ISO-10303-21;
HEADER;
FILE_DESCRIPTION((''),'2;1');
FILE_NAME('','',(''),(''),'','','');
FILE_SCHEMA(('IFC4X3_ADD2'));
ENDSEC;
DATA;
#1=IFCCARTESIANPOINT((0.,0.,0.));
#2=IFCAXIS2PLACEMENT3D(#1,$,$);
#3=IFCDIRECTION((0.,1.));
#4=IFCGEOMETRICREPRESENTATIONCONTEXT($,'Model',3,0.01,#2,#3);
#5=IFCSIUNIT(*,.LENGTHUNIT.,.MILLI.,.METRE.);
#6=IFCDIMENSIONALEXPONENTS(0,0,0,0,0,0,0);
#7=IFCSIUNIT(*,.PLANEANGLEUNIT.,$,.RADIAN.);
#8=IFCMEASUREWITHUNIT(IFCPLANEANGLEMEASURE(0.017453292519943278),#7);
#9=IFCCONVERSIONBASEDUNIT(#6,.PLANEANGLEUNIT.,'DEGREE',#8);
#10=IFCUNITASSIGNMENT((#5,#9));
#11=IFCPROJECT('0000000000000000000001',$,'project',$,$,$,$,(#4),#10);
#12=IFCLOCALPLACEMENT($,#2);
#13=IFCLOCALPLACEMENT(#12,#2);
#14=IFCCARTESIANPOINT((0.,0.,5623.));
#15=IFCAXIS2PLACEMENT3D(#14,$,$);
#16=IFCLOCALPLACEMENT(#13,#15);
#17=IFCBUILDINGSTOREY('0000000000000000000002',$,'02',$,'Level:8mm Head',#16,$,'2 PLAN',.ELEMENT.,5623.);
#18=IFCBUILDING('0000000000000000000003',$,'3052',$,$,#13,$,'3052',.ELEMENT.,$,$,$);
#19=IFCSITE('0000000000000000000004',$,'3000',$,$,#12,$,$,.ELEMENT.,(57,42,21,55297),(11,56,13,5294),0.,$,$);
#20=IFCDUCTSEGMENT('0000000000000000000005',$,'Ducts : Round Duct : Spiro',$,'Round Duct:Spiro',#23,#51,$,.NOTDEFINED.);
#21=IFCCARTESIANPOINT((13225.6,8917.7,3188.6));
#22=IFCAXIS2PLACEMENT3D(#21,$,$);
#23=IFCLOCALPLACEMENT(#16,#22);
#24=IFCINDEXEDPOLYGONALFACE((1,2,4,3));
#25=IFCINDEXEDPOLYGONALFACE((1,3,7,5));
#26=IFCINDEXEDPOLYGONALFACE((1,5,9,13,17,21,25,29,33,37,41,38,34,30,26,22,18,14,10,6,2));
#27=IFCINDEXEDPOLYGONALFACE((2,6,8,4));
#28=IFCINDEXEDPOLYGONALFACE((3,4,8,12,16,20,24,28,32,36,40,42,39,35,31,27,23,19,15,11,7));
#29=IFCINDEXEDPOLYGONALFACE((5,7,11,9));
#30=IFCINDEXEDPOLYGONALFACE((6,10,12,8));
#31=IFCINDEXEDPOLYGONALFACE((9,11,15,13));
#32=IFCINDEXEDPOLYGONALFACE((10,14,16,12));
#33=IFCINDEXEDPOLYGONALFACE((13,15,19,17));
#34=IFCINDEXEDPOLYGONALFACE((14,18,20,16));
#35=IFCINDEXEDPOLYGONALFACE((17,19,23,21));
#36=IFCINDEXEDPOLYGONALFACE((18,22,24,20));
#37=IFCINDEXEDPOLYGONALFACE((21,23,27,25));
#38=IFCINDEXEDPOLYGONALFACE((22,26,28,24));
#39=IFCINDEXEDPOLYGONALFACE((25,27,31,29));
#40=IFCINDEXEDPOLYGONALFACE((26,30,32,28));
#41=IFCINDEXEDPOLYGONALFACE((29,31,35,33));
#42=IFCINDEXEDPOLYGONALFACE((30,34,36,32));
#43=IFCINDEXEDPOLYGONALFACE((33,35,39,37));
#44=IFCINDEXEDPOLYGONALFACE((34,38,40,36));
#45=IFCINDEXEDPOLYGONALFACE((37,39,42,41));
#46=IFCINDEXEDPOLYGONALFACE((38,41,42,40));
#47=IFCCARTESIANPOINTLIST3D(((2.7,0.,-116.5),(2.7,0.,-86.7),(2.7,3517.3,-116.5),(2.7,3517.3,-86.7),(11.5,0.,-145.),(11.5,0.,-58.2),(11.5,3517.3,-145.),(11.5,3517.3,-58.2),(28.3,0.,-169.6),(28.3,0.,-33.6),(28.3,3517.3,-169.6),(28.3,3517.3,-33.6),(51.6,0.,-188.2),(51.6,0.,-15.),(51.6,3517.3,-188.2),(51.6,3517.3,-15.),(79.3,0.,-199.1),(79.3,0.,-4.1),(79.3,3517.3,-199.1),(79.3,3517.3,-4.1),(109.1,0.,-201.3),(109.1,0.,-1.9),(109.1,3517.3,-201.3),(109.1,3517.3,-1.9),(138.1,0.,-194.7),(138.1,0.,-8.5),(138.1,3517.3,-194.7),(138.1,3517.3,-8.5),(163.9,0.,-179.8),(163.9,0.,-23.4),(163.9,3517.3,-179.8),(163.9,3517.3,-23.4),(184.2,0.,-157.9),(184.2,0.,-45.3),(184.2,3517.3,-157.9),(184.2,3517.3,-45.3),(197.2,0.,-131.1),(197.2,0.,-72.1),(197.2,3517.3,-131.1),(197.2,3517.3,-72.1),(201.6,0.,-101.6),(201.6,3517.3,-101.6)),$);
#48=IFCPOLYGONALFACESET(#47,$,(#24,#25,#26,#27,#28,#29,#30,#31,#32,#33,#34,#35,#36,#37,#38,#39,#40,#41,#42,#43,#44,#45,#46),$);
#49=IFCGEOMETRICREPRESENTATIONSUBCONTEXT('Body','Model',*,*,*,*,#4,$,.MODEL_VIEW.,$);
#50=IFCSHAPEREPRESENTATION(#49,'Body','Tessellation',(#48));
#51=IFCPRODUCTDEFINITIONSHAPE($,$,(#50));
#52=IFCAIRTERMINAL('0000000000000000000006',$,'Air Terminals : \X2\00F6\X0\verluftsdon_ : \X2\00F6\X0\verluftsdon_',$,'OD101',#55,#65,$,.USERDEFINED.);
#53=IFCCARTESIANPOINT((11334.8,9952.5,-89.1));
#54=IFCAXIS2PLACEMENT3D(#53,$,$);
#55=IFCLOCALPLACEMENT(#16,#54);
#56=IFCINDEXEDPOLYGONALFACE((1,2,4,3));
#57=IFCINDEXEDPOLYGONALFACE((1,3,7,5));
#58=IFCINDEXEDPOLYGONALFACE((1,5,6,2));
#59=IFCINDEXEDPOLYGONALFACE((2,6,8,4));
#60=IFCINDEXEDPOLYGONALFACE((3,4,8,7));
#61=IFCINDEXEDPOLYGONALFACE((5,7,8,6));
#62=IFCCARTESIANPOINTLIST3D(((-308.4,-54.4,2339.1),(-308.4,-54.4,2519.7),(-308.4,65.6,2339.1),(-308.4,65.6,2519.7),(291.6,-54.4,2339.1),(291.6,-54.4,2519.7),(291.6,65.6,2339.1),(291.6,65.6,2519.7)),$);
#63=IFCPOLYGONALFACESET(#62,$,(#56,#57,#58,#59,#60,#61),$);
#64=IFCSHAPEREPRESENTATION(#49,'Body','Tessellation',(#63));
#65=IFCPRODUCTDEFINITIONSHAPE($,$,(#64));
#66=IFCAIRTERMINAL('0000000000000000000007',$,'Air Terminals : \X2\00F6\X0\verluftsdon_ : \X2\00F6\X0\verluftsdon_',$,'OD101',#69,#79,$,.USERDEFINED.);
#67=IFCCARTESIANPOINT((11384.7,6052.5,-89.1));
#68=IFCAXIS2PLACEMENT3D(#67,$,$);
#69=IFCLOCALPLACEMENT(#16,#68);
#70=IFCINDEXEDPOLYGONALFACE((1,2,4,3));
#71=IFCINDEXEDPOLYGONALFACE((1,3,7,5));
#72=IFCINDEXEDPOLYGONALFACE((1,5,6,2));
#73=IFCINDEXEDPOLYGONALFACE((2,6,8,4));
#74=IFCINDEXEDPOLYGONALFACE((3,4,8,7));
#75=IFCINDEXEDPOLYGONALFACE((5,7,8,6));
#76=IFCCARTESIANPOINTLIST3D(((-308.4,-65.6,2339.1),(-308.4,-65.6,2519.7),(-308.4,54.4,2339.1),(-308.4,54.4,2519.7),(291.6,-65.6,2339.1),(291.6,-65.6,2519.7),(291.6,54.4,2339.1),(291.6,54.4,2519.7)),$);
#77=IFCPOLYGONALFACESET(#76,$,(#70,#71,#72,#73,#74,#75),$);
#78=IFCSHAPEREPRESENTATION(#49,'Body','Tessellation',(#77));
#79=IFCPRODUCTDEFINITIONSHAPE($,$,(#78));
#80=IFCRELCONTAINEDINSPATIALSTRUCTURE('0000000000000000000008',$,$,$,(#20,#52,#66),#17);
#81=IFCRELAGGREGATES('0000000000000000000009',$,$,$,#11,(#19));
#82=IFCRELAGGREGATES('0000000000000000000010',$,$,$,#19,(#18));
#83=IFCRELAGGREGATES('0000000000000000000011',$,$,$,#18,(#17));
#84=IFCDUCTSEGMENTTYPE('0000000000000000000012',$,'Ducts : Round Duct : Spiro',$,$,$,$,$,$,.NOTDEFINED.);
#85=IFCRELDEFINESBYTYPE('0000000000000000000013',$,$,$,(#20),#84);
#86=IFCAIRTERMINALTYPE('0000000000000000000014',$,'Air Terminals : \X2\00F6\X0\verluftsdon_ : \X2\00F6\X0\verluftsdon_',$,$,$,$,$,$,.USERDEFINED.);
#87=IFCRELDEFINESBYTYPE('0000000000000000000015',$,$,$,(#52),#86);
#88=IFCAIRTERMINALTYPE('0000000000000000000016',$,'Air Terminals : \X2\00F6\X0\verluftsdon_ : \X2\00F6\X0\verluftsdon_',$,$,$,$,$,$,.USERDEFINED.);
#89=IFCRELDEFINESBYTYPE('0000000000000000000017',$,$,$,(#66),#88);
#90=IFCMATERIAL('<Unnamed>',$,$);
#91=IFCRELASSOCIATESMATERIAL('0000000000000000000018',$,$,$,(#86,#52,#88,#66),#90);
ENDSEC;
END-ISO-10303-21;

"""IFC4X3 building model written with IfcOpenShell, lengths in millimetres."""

from ifc_helpers import new_model, entity, si_unit, converted_unit, direction, frame, origin, origin_2d_with_axis, place, context, subcontext, project, spatial, rectangle, circle, extrude, source, transform, mapped, material, type_object, type_shapes, element, save


model = new_model("IFC4X3")

# Units and contexts
model_context = context("Model", 3, precision=0.01, world=origin(), true_north=direction((0.0, 1.0)))
body_context = subcontext(model_context, "Body", "Model", "MODEL_VIEW")
ifc_project = project(units=[si_unit("LENGTHUNIT", "METRE", prefix="MILLI"), converted_unit("PLANEANGLEUNIT", "DEGREE", entity("IfcPlaneAngleMeasure", 0.017453292519943278), si_unit("PLANEANGLEUNIT", "RADIAN"), dimensions=[0, 0, 0, 0, 0, 0, 0])], contexts=[model_context])

# Site, building, storey
site_placement = place(None, origin())
site = spatial("IfcSite", under=ifc_project, at=site_placement, Name="3000", CompositionType="ELEMENT", RefLatitude=(57, 42, 21, 55297), RefLongitude=(11, 56, 13, 5294), RefElevation=0.0)
building_placement = place(site_placement, origin())
building = spatial("IfcBuilding", under=site, at=building_placement, Name="3052", LongName="3052", CompositionType="ELEMENT")
storey_placement = place(building_placement, frame((0.0, 0.0, 5623.0)))
storey = spatial("IfcBuildingStorey", under=building, at=storey_placement, Name="02", ObjectType="Level:8mm Head", LongName="2 PLAN", CompositionType="ELEMENT", Elevation=5623.0)

# Duct segment
duct_segment_type = type_object("IfcDuctSegmentType", Name="Ducts : Round Duct : Spiro", PredefinedType="NOTDEFINED")
duct_segment_1_placement = place(storey_placement, frame((13225.6, 8917.7, 3188.6)))
element("IfcDuctSegment", 1, at=duct_segment_1_placement, inside=storey, type_object=duct_segment_type, Name="Ducts : Round Duct : Spiro", ObjectType="Round Duct:Spiro", PredefinedType="NOTDEFINED", context=body_context, shape_type="SweptSolid", body=[
    extrude(circle(Radius=100.0, at=origin_2d_with_axis()), frame((101.6, 0.0, -101.6), z_axis=(0.0, 1.0, 0.0), x_axis=(1.0, 0.0, 0.0)), (0.0, 0.0, 1.0), 3517.3),
])

# Shared definitions
ifc_material_1 = material(Name="<Unnamed>")

# Air terminals
air_terminal_type_1 = type_object("IfcAirTerminalType", Name="Air Terminals : överluftsdon_ : överluftsdon_", PredefinedType="USERDEFINED", material=ifc_material_1)
shared_shape_1 = source(origin(), body_context, "Body", "SweptSolid", [
    extrude(rectangle(XDim=600.0, YDim=120.0, at=origin_2d_with_axis()), frame((-8.4, 5.6, 2339.1), z_axis=(0.0, 0.0, 1.0), x_axis=(-1.0, 0.0, 0.0)), (0.0, 0.0, 1.0), 180.7),
])
type_shapes(air_terminal_type_1, [shared_shape_1])
air_terminal_1_placement = place(storey_placement, frame((11334.8, 9952.5, -89.1)))
element("IfcAirTerminal", 2, at=air_terminal_1_placement, inside=storey, type_object=air_terminal_type_1, material=ifc_material_1, Name="Air Terminals : överluftsdon_ : överluftsdon_", ObjectType="OD101", PredefinedType="USERDEFINED", context=body_context, shape_type="MappedRepresentation", body=[
    mapped(shared_shape_1, transform((0.0, 0.0, 0.0), scale=1.0)),
])
air_terminal_type_2 = type_object("IfcAirTerminalType", Name="Air Terminals : överluftsdon_ : överluftsdon_", PredefinedType="USERDEFINED", material=ifc_material_1)
shared_shape_2 = source(origin(), body_context, "Body", "SweptSolid", [
    extrude(rectangle(XDim=120.0, YDim=600.0, at=origin_2d_with_axis()), frame((-8.4, -5.6, 2339.1), z_axis=(0.0, 0.0, 1.0), x_axis=(0.0, 1.0, 0.0)), (0.0, 0.0, 1.0), 180.7),
])
type_shapes(air_terminal_type_2, [shared_shape_2])
air_terminal_2_placement = place(storey_placement, frame((11384.7, 6052.5, -89.1)))
element("IfcAirTerminal", 3, at=air_terminal_2_placement, inside=storey, type_object=air_terminal_type_2, material=ifc_material_1, Name="Air Terminals : överluftsdon_ : överluftsdon_", ObjectType="OD101", PredefinedType="USERDEFINED", context=body_context, shape_type="MappedRepresentation", body=[
    mapped(shared_shape_2, transform((0.0, 0.0, 0.0), scale=1.0)),
])

save(model, "model.ifc")
